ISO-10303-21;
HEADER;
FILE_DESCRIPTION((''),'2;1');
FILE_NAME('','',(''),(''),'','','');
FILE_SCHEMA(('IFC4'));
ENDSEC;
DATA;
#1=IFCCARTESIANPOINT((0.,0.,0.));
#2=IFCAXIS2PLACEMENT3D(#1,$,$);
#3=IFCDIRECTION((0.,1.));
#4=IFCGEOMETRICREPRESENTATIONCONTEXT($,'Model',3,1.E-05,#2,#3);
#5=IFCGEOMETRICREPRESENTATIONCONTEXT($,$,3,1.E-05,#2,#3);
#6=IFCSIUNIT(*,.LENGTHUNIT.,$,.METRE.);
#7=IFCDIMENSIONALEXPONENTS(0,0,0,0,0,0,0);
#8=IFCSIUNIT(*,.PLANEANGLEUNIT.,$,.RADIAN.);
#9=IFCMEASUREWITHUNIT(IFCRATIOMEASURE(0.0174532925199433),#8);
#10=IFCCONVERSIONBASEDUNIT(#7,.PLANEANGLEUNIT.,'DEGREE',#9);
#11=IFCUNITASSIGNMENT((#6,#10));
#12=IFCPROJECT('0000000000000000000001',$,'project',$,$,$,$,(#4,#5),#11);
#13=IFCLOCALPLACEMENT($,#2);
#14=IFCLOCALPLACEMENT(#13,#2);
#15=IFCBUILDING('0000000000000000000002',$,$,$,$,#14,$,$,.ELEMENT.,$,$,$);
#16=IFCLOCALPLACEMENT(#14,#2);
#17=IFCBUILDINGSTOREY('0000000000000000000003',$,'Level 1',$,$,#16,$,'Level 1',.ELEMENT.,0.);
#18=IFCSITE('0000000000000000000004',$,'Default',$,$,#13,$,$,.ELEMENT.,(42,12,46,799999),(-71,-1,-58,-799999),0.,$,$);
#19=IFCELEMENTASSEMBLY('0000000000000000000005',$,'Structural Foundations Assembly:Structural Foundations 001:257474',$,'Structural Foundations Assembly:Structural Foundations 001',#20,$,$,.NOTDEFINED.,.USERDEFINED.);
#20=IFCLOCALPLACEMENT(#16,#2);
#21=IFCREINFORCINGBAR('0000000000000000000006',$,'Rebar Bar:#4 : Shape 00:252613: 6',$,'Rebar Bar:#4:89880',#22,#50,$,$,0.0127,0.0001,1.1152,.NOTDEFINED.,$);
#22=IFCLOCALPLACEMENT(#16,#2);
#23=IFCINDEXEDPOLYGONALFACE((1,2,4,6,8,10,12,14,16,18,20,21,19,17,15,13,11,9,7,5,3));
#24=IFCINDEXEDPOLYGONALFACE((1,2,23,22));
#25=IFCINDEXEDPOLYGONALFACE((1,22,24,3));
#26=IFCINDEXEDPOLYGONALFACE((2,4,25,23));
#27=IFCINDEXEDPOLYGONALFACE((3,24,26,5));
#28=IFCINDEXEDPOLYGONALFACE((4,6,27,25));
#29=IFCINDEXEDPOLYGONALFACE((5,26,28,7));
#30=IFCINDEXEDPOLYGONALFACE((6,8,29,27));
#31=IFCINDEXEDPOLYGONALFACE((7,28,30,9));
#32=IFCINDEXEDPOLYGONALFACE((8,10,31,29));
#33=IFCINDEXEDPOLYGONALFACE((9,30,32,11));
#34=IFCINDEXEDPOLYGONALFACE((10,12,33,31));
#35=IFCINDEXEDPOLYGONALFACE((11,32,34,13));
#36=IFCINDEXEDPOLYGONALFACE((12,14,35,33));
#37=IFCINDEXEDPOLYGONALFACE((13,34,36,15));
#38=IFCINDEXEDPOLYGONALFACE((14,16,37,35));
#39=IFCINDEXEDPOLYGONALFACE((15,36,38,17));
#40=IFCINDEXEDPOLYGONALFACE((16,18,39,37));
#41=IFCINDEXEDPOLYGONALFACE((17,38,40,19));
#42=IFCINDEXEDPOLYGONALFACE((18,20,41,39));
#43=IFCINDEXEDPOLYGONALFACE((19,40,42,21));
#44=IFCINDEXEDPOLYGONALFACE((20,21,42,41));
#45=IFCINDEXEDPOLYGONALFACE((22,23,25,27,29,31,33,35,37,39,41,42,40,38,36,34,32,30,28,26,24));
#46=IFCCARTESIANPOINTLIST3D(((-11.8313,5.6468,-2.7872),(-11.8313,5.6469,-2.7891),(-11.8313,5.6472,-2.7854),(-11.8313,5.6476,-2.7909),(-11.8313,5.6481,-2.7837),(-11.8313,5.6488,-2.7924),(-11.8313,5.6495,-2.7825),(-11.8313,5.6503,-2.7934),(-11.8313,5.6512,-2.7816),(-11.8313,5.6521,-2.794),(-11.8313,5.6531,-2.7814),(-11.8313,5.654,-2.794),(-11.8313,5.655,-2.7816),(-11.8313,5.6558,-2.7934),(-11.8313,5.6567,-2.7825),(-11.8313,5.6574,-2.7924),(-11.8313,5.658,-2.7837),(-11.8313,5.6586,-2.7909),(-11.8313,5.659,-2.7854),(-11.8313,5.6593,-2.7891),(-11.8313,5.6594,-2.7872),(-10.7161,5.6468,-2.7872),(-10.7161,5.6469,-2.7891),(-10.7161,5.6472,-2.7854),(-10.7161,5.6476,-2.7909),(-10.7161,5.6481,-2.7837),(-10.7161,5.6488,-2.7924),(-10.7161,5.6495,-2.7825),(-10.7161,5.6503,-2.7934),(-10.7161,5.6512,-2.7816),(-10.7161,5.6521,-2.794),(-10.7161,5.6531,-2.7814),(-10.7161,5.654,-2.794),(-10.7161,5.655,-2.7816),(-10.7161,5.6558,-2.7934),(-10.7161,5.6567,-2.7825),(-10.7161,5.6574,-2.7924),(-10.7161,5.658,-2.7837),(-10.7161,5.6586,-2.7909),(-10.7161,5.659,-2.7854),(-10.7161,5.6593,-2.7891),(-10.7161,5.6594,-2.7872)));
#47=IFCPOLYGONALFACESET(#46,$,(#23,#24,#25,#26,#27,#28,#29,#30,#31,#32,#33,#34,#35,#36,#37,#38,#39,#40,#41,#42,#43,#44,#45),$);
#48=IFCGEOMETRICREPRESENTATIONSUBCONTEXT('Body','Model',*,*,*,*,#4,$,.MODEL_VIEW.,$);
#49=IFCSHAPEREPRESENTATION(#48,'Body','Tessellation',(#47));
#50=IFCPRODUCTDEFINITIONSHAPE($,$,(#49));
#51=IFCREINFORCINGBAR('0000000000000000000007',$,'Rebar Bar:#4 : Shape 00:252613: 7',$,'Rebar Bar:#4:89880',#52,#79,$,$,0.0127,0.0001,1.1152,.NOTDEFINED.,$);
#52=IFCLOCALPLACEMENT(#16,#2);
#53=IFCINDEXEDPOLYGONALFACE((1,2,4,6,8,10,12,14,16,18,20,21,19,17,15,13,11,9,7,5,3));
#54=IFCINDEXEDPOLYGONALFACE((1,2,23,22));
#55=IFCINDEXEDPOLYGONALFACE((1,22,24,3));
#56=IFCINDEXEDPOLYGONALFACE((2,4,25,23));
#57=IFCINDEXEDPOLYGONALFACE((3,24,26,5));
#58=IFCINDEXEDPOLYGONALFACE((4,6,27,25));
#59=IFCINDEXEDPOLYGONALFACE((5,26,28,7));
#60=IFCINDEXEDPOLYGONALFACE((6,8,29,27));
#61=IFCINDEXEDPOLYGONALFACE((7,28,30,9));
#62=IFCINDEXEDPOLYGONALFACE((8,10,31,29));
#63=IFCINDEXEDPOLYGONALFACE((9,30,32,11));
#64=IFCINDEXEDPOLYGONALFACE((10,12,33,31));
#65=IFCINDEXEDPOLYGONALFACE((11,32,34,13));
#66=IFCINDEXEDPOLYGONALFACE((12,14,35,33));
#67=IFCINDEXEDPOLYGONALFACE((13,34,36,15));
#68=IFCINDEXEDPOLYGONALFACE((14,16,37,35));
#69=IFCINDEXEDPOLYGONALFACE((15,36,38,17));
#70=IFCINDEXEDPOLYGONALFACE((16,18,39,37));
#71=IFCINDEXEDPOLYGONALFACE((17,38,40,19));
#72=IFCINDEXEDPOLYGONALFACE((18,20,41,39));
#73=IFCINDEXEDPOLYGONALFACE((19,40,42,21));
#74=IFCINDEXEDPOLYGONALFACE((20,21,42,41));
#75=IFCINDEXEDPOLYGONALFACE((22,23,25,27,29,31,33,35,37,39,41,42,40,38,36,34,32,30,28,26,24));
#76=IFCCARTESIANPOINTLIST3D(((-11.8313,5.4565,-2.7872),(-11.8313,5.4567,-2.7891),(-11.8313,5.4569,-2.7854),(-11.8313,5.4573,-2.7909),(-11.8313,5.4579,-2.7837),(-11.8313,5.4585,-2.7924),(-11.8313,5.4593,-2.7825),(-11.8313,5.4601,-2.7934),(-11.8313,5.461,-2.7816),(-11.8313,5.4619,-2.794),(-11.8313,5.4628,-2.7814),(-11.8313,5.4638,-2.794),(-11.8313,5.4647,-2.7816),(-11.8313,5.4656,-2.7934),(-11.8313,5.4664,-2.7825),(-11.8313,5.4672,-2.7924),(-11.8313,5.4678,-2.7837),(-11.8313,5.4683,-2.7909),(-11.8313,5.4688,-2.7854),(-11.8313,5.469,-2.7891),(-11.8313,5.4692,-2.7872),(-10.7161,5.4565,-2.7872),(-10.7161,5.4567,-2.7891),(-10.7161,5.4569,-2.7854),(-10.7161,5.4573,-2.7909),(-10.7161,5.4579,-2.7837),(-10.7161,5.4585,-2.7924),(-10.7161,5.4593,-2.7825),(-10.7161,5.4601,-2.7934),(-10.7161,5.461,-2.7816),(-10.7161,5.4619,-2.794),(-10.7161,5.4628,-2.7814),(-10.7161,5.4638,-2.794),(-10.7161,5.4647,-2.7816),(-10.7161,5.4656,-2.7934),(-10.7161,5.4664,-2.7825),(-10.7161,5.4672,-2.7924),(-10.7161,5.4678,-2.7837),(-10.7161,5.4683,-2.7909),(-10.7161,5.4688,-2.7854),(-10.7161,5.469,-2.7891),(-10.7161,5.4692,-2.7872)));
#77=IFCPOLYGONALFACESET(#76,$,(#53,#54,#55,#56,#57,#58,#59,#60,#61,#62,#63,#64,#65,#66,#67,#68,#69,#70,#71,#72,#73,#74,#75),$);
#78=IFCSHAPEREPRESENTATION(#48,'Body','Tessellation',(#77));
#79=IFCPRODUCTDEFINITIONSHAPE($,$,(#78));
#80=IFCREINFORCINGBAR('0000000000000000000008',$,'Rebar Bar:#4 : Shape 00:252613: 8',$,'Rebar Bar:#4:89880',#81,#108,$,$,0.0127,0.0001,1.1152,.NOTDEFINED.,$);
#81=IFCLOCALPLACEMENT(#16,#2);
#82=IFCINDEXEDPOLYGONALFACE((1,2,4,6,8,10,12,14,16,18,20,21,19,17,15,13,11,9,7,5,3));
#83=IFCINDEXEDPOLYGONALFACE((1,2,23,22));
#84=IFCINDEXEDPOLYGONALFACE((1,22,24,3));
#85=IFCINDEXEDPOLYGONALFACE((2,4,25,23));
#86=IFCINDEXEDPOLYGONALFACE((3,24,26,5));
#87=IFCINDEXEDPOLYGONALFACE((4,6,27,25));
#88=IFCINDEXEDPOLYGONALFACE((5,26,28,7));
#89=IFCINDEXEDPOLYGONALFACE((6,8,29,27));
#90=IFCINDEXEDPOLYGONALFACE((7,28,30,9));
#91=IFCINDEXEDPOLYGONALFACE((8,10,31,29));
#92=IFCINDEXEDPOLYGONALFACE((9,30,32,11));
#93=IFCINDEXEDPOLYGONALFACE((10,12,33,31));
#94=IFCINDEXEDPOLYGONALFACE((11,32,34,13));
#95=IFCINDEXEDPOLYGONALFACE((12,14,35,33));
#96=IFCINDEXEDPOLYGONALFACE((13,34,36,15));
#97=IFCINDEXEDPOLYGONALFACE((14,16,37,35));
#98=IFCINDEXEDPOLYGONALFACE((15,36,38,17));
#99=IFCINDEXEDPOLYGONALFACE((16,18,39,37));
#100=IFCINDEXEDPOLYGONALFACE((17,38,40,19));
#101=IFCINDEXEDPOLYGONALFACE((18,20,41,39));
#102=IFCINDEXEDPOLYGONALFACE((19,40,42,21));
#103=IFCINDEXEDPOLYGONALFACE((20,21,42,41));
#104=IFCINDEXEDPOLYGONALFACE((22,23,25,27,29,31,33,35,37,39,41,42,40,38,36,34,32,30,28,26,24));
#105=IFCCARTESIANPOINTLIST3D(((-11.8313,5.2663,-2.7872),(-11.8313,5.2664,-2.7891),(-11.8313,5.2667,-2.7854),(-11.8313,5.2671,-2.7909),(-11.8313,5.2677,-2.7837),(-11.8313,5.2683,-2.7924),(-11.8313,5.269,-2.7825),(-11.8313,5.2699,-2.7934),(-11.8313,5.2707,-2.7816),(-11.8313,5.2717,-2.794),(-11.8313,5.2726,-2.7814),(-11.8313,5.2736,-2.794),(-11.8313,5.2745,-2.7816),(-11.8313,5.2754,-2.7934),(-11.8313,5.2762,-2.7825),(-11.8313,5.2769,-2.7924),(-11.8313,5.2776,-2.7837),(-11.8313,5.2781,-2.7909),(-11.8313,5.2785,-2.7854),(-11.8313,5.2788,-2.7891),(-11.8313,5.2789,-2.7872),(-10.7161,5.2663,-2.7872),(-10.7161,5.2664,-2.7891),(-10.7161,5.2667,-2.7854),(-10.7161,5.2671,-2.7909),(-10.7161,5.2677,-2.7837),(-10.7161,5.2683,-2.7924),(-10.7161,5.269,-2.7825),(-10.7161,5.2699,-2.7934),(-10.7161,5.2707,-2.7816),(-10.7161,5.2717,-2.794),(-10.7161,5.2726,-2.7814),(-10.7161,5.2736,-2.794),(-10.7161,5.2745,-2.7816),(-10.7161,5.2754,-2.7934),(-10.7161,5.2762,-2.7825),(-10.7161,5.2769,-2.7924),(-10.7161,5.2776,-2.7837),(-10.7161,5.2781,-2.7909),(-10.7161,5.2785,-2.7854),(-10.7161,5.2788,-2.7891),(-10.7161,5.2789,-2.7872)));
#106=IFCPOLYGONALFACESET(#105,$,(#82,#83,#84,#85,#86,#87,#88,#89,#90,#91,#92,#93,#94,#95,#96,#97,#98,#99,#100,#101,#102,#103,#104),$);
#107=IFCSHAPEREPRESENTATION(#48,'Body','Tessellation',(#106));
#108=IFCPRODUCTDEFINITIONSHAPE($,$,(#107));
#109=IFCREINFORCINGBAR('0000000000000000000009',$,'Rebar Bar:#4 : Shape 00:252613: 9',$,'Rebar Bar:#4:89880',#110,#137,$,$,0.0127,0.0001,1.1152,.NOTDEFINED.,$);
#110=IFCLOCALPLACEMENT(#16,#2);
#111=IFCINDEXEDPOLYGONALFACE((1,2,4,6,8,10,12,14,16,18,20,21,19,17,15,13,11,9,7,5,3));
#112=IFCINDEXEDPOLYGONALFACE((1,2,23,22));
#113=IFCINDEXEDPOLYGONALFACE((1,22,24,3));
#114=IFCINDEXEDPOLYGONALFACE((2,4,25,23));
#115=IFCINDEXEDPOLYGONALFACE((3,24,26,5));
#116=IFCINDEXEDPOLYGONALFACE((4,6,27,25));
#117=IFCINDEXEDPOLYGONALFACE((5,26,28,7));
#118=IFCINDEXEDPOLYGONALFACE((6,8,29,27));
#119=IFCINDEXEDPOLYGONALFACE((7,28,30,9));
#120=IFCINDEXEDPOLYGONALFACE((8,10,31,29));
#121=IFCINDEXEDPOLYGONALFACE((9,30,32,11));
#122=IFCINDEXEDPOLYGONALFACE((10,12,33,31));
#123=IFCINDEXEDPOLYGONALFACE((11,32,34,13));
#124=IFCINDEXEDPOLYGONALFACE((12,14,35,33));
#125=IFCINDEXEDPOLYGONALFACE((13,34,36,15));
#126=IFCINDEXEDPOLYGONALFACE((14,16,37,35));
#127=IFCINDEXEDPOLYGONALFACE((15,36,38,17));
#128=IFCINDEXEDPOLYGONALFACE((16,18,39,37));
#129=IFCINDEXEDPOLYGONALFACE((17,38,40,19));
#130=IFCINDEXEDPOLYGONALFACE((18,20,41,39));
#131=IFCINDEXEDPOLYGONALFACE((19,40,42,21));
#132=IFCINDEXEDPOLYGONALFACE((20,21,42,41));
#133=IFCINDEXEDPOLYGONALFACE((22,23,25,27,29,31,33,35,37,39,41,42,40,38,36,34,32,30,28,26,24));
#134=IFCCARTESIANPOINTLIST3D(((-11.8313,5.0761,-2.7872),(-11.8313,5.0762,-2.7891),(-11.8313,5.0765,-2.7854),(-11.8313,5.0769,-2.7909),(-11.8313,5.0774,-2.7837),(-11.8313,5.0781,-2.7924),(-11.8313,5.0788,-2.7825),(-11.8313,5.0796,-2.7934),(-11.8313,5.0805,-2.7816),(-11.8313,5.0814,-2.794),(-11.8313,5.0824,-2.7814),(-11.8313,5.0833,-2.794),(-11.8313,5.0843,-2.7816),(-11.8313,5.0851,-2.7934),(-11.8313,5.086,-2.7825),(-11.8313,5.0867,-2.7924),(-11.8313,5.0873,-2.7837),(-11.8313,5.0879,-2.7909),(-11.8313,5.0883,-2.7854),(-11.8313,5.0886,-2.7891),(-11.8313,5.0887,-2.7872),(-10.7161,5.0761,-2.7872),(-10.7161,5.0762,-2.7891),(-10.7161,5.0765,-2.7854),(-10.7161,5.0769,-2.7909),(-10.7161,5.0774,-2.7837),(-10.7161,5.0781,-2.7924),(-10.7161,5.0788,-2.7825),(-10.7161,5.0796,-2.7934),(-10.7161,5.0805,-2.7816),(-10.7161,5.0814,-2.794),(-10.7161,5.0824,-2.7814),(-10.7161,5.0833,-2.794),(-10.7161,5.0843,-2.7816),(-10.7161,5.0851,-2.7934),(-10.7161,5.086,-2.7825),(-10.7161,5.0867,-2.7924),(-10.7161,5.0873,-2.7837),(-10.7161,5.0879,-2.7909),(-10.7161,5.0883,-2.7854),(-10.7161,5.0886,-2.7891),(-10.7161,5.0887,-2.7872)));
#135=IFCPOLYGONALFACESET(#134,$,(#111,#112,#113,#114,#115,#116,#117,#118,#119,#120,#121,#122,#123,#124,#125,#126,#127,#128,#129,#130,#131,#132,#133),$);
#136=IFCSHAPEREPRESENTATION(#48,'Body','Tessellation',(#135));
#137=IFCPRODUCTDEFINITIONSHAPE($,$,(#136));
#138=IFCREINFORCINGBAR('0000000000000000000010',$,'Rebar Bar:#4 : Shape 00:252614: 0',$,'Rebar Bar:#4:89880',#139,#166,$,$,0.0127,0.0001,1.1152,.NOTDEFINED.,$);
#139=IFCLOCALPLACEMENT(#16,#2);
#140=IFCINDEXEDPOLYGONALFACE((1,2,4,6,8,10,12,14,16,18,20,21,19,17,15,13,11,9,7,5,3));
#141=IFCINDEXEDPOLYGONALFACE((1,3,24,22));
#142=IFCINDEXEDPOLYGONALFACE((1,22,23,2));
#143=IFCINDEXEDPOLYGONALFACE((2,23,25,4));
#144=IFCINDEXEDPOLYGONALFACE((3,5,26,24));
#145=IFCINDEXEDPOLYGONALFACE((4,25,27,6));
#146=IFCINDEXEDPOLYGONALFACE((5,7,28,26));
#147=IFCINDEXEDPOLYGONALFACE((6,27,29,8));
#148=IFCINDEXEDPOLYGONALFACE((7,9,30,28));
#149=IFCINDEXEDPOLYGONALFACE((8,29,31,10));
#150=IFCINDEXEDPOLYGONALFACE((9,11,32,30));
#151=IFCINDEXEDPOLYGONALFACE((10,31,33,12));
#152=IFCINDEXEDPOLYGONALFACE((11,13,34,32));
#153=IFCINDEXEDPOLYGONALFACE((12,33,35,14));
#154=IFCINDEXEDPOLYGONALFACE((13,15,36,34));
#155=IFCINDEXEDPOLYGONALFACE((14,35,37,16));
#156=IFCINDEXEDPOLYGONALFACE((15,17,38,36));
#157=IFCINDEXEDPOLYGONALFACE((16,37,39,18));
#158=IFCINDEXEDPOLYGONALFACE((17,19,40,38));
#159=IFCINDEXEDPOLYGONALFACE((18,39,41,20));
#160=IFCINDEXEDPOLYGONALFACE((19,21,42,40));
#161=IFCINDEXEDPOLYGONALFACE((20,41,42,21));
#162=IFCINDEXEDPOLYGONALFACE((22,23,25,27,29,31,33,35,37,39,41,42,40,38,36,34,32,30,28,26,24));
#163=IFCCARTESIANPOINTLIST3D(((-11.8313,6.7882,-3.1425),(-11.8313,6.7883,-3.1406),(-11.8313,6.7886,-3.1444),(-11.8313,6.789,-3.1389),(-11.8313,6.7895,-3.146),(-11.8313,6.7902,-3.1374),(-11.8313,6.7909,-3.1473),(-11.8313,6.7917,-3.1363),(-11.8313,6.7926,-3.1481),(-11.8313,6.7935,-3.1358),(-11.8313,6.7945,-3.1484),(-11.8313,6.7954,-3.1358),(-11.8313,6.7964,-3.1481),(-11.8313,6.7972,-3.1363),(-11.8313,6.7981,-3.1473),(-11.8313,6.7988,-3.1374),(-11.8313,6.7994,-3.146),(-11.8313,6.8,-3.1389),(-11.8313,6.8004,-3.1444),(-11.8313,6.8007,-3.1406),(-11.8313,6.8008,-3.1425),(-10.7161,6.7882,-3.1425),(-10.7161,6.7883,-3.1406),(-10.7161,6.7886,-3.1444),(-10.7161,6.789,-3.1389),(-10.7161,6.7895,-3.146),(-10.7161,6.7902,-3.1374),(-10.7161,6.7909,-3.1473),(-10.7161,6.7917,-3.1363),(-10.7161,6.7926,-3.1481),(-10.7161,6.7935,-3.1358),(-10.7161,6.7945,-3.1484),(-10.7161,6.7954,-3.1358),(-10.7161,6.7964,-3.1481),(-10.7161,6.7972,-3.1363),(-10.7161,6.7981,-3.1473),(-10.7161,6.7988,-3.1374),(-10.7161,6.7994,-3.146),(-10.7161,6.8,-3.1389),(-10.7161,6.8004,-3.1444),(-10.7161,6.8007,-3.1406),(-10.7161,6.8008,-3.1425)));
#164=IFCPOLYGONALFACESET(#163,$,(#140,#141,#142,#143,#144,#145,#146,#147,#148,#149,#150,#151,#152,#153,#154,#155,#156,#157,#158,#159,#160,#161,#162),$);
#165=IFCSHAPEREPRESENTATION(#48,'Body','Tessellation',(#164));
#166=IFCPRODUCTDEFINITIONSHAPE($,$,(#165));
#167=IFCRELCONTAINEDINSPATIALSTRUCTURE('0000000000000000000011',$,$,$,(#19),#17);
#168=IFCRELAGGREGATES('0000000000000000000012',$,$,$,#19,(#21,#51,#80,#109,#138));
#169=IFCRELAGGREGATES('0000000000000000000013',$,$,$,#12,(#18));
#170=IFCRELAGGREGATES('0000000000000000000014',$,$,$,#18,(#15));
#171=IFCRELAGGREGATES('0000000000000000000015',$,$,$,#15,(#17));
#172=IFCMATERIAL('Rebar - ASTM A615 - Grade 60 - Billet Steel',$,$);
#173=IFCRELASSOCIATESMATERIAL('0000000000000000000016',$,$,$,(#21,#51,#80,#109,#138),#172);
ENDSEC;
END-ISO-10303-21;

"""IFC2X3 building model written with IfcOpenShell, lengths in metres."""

from ifc_helpers import new_model, entity, si_unit, converted_unit, direction, origin, place, context, subcontext, project, spatial, material, element, aggregate, save


model = new_model("IFC2X3")

# Units and contexts
model_context = context("Model", 3, precision=1e-05, world=origin(), true_north=direction((0.0, 1.0)))
context_of_model = context(None, 3, precision=1e-05, world=origin(), true_north=direction((0.0, 1.0)))
body_context = subcontext(model_context, "Body", "Model", "MODEL_VIEW")
ifc_project = project(units=[si_unit("LENGTHUNIT", "METRE"), converted_unit("PLANEANGLEUNIT", "DEGREE", entity("IfcRatioMeasure", 0.0174532925199433), si_unit("PLANEANGLEUNIT", "RADIAN"), dimensions=[0, 0, 0, 0, 0, 0, 0])], contexts=[model_context, context_of_model])

# Site, building, storey
site_placement = place(None, origin())
site = spatial("IfcSite", under=ifc_project, at=site_placement, Name="Default", CompositionType="ELEMENT", RefLatitude=(42, 12, 46, 799999), RefLongitude=(-71, -1, -58, -799999), RefElevation=0.0)
building_placement = place(site_placement, origin())
building = spatial("IfcBuilding", under=site, at=building_placement, CompositionType="ELEMENT")
storey_placement = place(building_placement, origin())
storey = spatial("IfcBuildingStorey", under=building, at=storey_placement, Name="Level 1", LongName="Level 1", CompositionType="ELEMENT", Elevation=0.0)

# Element assembly, reinforcing bars
assembly_placement = place(storey_placement, origin())
assembly = element("IfcElementAssembly", 1, at=assembly_placement, inside=storey, Name="Structural Foundations Assembly:Structural Foundations 001:257474", ObjectType="Structural Foundations Assembly:Structural Foundations 001", AssemblyPlace="NOTDEFINED", PredefinedType="USERDEFINED")
ifc_material = material(Name="Rebar - ASTM A615 - Grade 60 - Billet Steel")
reinforcing_bar_1_placement = place(assembly_placement, origin())
reinforcing_bar_1 = element("IfcReinforcingBar", 2, at=reinforcing_bar_1_placement, material=ifc_material, Name="Rebar Bar:#4 : Shape 00:252613: 6", ObjectType="Rebar Bar:#4:89880", BarLength=1.1152, BarRole="NOTDEFINED", CrossSectionArea=0.0001, NominalDiameter=0.0127, context=body_context, shape_type="AdvancedSweptSolid", body=[
    entity("IfcSweptDiskSolid", entity("IfcCompositeCurve", [entity("IfcCompositeCurveSegment", "CONTINUOUS", True, entity("IfcPolyline", [entity("IfcCartesianPoint", [-11.8313, 5.6531, -2.7877]), entity("IfcCartesianPoint", [-10.7161, 5.6531, -2.7877])]))], False), 0.0063, None, 0.0, 1.0),
])
reinforcing_bar_2_placement = place(assembly_placement, origin())
reinforcing_bar_2 = element("IfcReinforcingBar", 3, at=reinforcing_bar_2_placement, material=ifc_material, Name="Rebar Bar:#4 : Shape 00:252613: 7", ObjectType="Rebar Bar:#4:89880", BarLength=1.1152, BarRole="NOTDEFINED", CrossSectionArea=0.0001, NominalDiameter=0.0127, context=body_context, shape_type="AdvancedSweptSolid", body=[
    entity("IfcSweptDiskSolid", entity("IfcCompositeCurve", [entity("IfcCompositeCurveSegment", "CONTINUOUS", True, entity("IfcPolyline", [entity("IfcCartesianPoint", [-11.8313, 5.4628, -2.7877]), entity("IfcCartesianPoint", [-10.7161, 5.4628, -2.7877])]))], False), 0.0063, None, 0.0, 1.0),
])
reinforcing_bar_3_placement = place(assembly_placement, origin())
reinforcing_bar_3 = element("IfcReinforcingBar", 4, at=reinforcing_bar_3_placement, material=ifc_material, Name="Rebar Bar:#4 : Shape 00:252613: 8", ObjectType="Rebar Bar:#4:89880", BarLength=1.1152, BarRole="NOTDEFINED", CrossSectionArea=0.0001, NominalDiameter=0.0127, context=body_context, shape_type="AdvancedSweptSolid", body=[
    entity("IfcSweptDiskSolid", entity("IfcCompositeCurve", [entity("IfcCompositeCurveSegment", "CONTINUOUS", True, entity("IfcPolyline", [entity("IfcCartesianPoint", [-11.8313, 5.2726, -2.7877]), entity("IfcCartesianPoint", [-10.7161, 5.2726, -2.7877])]))], False), 0.0063, None, 0.0, 1.0),
])
reinforcing_bar_4_placement = place(assembly_placement, origin())
reinforcing_bar_4 = element("IfcReinforcingBar", 5, at=reinforcing_bar_4_placement, material=ifc_material, Name="Rebar Bar:#4 : Shape 00:252613: 9", ObjectType="Rebar Bar:#4:89880", BarLength=1.1152, BarRole="NOTDEFINED", CrossSectionArea=0.0001, NominalDiameter=0.0127, context=body_context, shape_type="AdvancedSweptSolid", body=[
    entity("IfcSweptDiskSolid", entity("IfcCompositeCurve", [entity("IfcCompositeCurveSegment", "CONTINUOUS", True, entity("IfcPolyline", [entity("IfcCartesianPoint", [-11.8313, 5.0824, -2.7877]), entity("IfcCartesianPoint", [-10.7161, 5.0824, -2.7877])]))], False), 0.0063, None, 0.0, 1.0),
])
reinforcing_bar_5_placement = place(assembly_placement, origin())
reinforcing_bar_5 = element("IfcReinforcingBar", 6, at=reinforcing_bar_5_placement, material=ifc_material, Name="Rebar Bar:#4 : Shape 00:252614: 0", ObjectType="Rebar Bar:#4:89880", BarLength=1.1152, BarRole="NOTDEFINED", CrossSectionArea=0.0001, NominalDiameter=0.0127, context=body_context, shape_type="AdvancedSweptSolid", body=[
    entity("IfcSweptDiskSolid", entity("IfcCompositeCurve", [entity("IfcCompositeCurveSegment", "CONTINUOUS", True, entity("IfcPolyline", [entity("IfcCartesianPoint", [-10.7161, 6.7945, -3.142]), entity("IfcCartesianPoint", [-11.8313, 6.7945, -3.142])]))], False), 0.0063, None, 0.0, 1.0),
])
aggregate(assembly, [reinforcing_bar_1, reinforcing_bar_2, reinforcing_bar_3, reinforcing_bar_4, reinforcing_bar_5])

save(model, "model.ifc")
